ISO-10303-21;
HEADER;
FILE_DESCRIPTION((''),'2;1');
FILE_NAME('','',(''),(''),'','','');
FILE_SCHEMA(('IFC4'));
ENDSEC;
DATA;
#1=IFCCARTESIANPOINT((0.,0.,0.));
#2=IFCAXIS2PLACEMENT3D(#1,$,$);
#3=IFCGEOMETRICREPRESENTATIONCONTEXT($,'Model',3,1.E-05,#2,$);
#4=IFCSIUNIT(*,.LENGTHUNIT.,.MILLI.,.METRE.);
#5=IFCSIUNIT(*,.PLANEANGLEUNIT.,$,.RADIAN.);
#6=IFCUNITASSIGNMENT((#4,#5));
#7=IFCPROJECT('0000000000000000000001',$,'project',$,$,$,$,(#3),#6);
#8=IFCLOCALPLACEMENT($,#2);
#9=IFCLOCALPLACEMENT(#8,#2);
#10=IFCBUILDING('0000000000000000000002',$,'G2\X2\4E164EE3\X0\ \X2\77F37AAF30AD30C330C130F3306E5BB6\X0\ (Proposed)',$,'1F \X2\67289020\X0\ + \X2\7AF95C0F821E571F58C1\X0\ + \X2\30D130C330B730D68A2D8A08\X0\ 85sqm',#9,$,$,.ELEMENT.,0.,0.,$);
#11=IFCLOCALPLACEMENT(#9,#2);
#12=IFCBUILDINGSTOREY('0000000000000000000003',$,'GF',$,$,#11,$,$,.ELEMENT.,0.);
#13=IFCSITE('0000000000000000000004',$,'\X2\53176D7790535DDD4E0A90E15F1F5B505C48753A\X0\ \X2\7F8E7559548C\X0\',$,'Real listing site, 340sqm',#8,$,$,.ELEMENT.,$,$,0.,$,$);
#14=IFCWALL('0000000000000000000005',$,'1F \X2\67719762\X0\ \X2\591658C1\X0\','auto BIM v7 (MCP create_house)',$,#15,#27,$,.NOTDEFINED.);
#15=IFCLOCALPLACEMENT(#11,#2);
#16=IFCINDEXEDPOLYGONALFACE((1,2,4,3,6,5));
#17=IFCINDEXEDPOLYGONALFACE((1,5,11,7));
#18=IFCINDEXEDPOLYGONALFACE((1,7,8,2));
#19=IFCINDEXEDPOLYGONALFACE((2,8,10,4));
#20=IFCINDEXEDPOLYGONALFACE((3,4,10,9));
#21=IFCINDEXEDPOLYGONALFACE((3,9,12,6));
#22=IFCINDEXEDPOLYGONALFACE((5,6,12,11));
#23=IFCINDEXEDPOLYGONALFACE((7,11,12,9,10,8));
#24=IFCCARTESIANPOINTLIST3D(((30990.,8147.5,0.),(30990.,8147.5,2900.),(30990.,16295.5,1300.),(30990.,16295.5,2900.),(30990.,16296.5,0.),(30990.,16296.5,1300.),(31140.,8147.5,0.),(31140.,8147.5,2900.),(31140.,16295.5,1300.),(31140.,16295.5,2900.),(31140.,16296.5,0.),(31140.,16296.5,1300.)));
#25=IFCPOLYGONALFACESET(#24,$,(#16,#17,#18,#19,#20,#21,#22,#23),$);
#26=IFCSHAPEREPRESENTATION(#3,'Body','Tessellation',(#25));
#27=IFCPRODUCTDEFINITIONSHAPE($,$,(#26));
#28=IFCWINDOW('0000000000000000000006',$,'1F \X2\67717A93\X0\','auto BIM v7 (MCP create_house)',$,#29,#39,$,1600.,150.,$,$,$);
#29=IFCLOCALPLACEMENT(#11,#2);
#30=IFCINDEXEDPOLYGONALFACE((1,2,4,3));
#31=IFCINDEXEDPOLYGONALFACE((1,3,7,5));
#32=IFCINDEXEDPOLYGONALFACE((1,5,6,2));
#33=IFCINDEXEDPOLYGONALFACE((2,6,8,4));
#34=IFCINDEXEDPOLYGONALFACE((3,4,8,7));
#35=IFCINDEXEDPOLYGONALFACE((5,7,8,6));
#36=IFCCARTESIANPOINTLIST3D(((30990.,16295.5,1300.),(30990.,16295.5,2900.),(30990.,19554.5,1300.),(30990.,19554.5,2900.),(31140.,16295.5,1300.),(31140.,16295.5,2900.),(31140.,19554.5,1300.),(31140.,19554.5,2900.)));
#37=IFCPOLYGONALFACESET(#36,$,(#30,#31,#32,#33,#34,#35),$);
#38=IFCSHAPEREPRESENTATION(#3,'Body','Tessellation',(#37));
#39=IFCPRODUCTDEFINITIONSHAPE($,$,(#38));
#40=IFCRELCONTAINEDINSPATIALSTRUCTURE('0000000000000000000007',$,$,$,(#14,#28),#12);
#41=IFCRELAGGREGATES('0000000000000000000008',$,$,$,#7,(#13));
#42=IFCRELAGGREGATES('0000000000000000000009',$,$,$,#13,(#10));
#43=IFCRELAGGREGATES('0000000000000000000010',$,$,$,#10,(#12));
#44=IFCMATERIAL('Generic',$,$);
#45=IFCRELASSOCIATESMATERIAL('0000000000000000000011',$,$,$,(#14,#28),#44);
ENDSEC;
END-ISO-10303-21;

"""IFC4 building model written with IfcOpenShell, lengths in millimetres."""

from ifc_helpers import new_model, si_unit, frame, frame_2d, origin, place, context, project, spatial, rectangle, extrude, material, element, fill, save


model = new_model("IFC4")

# Units and contexts
model_context = context("Model", 3, precision=1e-05, world=origin())
ifc_project = project(units=[si_unit("LENGTHUNIT", "METRE", prefix="MILLI"), si_unit("PLANEANGLEUNIT", "RADIAN")], contexts=[model_context])

# Site, building, storey
site_placement = place(None, origin())
site = spatial("IfcSite", under=ifc_project, at=site_placement, Name="北海道川上郡弟子屈町 美留和", ObjectType="Real listing site, 340sqm", CompositionType="ELEMENT", RefElevation=0.0)
building_placement = place(site_placement, origin())
building = spatial("IfcBuilding", under=site, at=building_placement, Name="G2世代 石窯キッチンの家 (Proposed)", ObjectType="1F 木造 + 竹小舞土壁 + パッシブ設計 85sqm", CompositionType="ELEMENT", ElevationOfRefHeight=0.0, ElevationOfTerrain=0.0)
storey_placement = place(building_placement, origin())
storey = spatial("IfcBuildingStorey", under=building, at=storey_placement, Name="GF", CompositionType="ELEMENT", Elevation=0.0)

# Shared definitions
ifc_material = material(Name="Generic")

# Wall, opening, window
wall_1_placement = place(storey_placement, frame((15495.0, 4074.0, 0.0)))
wall_1 = element("IfcWall", 1, at=wall_1_placement, inside=storey, material=ifc_material, Name="1F 東面 外壁", Description="auto BIM v7 (MCP create_house)", PredefinedType="NOTDEFINED", context=model_context, shape_type="SweptSolid", body=[
    extrude(rectangle(XDim=150.0, YDim=8149.0, at=frame_2d((75.0, 4074.0))), frame((15495.0, 4074.0, 0.0)), (0.0, 0.0, 1.0), 2900.0),
])
opening_1_placement = place(storey_placement, frame((15495.0, 8148.0, 650.0)))
opening_1 = element("IfcOpeningElement", 2, at=opening_1_placement, cuts=wall_1, PredefinedType="NOTDEFINED", context=model_context, shape_type="SweptSolid", body=[
    extrude(rectangle(XDim=150.0, YDim=3259.0, at=frame_2d((75.0, 1629.0))), frame((15495.0, 8148.0, 650.0)), (0.0, 0.0, 1.0), 1600.0),
])
window_1_placement = place(storey_placement, frame((15495.0, 8148.0, 650.0)))
window_1 = element("IfcWindow", 3, at=window_1_placement, inside=storey, material=ifc_material, Name="1F 東窓", Description="auto BIM v7 (MCP create_house)", OverallHeight=1600.0, OverallWidth=150.0, context=model_context, shape_type="SweptSolid", body=[
    extrude(rectangle(XDim=150.0, YDim=3259.0, at=frame_2d((75.0, 1629.0))), frame((15495.0, 8148.0, 650.0)), (0.0, 0.0, 1.0), 1600.0),
])
fill(opening_1, window_1)

save(model, "model.ifc")
